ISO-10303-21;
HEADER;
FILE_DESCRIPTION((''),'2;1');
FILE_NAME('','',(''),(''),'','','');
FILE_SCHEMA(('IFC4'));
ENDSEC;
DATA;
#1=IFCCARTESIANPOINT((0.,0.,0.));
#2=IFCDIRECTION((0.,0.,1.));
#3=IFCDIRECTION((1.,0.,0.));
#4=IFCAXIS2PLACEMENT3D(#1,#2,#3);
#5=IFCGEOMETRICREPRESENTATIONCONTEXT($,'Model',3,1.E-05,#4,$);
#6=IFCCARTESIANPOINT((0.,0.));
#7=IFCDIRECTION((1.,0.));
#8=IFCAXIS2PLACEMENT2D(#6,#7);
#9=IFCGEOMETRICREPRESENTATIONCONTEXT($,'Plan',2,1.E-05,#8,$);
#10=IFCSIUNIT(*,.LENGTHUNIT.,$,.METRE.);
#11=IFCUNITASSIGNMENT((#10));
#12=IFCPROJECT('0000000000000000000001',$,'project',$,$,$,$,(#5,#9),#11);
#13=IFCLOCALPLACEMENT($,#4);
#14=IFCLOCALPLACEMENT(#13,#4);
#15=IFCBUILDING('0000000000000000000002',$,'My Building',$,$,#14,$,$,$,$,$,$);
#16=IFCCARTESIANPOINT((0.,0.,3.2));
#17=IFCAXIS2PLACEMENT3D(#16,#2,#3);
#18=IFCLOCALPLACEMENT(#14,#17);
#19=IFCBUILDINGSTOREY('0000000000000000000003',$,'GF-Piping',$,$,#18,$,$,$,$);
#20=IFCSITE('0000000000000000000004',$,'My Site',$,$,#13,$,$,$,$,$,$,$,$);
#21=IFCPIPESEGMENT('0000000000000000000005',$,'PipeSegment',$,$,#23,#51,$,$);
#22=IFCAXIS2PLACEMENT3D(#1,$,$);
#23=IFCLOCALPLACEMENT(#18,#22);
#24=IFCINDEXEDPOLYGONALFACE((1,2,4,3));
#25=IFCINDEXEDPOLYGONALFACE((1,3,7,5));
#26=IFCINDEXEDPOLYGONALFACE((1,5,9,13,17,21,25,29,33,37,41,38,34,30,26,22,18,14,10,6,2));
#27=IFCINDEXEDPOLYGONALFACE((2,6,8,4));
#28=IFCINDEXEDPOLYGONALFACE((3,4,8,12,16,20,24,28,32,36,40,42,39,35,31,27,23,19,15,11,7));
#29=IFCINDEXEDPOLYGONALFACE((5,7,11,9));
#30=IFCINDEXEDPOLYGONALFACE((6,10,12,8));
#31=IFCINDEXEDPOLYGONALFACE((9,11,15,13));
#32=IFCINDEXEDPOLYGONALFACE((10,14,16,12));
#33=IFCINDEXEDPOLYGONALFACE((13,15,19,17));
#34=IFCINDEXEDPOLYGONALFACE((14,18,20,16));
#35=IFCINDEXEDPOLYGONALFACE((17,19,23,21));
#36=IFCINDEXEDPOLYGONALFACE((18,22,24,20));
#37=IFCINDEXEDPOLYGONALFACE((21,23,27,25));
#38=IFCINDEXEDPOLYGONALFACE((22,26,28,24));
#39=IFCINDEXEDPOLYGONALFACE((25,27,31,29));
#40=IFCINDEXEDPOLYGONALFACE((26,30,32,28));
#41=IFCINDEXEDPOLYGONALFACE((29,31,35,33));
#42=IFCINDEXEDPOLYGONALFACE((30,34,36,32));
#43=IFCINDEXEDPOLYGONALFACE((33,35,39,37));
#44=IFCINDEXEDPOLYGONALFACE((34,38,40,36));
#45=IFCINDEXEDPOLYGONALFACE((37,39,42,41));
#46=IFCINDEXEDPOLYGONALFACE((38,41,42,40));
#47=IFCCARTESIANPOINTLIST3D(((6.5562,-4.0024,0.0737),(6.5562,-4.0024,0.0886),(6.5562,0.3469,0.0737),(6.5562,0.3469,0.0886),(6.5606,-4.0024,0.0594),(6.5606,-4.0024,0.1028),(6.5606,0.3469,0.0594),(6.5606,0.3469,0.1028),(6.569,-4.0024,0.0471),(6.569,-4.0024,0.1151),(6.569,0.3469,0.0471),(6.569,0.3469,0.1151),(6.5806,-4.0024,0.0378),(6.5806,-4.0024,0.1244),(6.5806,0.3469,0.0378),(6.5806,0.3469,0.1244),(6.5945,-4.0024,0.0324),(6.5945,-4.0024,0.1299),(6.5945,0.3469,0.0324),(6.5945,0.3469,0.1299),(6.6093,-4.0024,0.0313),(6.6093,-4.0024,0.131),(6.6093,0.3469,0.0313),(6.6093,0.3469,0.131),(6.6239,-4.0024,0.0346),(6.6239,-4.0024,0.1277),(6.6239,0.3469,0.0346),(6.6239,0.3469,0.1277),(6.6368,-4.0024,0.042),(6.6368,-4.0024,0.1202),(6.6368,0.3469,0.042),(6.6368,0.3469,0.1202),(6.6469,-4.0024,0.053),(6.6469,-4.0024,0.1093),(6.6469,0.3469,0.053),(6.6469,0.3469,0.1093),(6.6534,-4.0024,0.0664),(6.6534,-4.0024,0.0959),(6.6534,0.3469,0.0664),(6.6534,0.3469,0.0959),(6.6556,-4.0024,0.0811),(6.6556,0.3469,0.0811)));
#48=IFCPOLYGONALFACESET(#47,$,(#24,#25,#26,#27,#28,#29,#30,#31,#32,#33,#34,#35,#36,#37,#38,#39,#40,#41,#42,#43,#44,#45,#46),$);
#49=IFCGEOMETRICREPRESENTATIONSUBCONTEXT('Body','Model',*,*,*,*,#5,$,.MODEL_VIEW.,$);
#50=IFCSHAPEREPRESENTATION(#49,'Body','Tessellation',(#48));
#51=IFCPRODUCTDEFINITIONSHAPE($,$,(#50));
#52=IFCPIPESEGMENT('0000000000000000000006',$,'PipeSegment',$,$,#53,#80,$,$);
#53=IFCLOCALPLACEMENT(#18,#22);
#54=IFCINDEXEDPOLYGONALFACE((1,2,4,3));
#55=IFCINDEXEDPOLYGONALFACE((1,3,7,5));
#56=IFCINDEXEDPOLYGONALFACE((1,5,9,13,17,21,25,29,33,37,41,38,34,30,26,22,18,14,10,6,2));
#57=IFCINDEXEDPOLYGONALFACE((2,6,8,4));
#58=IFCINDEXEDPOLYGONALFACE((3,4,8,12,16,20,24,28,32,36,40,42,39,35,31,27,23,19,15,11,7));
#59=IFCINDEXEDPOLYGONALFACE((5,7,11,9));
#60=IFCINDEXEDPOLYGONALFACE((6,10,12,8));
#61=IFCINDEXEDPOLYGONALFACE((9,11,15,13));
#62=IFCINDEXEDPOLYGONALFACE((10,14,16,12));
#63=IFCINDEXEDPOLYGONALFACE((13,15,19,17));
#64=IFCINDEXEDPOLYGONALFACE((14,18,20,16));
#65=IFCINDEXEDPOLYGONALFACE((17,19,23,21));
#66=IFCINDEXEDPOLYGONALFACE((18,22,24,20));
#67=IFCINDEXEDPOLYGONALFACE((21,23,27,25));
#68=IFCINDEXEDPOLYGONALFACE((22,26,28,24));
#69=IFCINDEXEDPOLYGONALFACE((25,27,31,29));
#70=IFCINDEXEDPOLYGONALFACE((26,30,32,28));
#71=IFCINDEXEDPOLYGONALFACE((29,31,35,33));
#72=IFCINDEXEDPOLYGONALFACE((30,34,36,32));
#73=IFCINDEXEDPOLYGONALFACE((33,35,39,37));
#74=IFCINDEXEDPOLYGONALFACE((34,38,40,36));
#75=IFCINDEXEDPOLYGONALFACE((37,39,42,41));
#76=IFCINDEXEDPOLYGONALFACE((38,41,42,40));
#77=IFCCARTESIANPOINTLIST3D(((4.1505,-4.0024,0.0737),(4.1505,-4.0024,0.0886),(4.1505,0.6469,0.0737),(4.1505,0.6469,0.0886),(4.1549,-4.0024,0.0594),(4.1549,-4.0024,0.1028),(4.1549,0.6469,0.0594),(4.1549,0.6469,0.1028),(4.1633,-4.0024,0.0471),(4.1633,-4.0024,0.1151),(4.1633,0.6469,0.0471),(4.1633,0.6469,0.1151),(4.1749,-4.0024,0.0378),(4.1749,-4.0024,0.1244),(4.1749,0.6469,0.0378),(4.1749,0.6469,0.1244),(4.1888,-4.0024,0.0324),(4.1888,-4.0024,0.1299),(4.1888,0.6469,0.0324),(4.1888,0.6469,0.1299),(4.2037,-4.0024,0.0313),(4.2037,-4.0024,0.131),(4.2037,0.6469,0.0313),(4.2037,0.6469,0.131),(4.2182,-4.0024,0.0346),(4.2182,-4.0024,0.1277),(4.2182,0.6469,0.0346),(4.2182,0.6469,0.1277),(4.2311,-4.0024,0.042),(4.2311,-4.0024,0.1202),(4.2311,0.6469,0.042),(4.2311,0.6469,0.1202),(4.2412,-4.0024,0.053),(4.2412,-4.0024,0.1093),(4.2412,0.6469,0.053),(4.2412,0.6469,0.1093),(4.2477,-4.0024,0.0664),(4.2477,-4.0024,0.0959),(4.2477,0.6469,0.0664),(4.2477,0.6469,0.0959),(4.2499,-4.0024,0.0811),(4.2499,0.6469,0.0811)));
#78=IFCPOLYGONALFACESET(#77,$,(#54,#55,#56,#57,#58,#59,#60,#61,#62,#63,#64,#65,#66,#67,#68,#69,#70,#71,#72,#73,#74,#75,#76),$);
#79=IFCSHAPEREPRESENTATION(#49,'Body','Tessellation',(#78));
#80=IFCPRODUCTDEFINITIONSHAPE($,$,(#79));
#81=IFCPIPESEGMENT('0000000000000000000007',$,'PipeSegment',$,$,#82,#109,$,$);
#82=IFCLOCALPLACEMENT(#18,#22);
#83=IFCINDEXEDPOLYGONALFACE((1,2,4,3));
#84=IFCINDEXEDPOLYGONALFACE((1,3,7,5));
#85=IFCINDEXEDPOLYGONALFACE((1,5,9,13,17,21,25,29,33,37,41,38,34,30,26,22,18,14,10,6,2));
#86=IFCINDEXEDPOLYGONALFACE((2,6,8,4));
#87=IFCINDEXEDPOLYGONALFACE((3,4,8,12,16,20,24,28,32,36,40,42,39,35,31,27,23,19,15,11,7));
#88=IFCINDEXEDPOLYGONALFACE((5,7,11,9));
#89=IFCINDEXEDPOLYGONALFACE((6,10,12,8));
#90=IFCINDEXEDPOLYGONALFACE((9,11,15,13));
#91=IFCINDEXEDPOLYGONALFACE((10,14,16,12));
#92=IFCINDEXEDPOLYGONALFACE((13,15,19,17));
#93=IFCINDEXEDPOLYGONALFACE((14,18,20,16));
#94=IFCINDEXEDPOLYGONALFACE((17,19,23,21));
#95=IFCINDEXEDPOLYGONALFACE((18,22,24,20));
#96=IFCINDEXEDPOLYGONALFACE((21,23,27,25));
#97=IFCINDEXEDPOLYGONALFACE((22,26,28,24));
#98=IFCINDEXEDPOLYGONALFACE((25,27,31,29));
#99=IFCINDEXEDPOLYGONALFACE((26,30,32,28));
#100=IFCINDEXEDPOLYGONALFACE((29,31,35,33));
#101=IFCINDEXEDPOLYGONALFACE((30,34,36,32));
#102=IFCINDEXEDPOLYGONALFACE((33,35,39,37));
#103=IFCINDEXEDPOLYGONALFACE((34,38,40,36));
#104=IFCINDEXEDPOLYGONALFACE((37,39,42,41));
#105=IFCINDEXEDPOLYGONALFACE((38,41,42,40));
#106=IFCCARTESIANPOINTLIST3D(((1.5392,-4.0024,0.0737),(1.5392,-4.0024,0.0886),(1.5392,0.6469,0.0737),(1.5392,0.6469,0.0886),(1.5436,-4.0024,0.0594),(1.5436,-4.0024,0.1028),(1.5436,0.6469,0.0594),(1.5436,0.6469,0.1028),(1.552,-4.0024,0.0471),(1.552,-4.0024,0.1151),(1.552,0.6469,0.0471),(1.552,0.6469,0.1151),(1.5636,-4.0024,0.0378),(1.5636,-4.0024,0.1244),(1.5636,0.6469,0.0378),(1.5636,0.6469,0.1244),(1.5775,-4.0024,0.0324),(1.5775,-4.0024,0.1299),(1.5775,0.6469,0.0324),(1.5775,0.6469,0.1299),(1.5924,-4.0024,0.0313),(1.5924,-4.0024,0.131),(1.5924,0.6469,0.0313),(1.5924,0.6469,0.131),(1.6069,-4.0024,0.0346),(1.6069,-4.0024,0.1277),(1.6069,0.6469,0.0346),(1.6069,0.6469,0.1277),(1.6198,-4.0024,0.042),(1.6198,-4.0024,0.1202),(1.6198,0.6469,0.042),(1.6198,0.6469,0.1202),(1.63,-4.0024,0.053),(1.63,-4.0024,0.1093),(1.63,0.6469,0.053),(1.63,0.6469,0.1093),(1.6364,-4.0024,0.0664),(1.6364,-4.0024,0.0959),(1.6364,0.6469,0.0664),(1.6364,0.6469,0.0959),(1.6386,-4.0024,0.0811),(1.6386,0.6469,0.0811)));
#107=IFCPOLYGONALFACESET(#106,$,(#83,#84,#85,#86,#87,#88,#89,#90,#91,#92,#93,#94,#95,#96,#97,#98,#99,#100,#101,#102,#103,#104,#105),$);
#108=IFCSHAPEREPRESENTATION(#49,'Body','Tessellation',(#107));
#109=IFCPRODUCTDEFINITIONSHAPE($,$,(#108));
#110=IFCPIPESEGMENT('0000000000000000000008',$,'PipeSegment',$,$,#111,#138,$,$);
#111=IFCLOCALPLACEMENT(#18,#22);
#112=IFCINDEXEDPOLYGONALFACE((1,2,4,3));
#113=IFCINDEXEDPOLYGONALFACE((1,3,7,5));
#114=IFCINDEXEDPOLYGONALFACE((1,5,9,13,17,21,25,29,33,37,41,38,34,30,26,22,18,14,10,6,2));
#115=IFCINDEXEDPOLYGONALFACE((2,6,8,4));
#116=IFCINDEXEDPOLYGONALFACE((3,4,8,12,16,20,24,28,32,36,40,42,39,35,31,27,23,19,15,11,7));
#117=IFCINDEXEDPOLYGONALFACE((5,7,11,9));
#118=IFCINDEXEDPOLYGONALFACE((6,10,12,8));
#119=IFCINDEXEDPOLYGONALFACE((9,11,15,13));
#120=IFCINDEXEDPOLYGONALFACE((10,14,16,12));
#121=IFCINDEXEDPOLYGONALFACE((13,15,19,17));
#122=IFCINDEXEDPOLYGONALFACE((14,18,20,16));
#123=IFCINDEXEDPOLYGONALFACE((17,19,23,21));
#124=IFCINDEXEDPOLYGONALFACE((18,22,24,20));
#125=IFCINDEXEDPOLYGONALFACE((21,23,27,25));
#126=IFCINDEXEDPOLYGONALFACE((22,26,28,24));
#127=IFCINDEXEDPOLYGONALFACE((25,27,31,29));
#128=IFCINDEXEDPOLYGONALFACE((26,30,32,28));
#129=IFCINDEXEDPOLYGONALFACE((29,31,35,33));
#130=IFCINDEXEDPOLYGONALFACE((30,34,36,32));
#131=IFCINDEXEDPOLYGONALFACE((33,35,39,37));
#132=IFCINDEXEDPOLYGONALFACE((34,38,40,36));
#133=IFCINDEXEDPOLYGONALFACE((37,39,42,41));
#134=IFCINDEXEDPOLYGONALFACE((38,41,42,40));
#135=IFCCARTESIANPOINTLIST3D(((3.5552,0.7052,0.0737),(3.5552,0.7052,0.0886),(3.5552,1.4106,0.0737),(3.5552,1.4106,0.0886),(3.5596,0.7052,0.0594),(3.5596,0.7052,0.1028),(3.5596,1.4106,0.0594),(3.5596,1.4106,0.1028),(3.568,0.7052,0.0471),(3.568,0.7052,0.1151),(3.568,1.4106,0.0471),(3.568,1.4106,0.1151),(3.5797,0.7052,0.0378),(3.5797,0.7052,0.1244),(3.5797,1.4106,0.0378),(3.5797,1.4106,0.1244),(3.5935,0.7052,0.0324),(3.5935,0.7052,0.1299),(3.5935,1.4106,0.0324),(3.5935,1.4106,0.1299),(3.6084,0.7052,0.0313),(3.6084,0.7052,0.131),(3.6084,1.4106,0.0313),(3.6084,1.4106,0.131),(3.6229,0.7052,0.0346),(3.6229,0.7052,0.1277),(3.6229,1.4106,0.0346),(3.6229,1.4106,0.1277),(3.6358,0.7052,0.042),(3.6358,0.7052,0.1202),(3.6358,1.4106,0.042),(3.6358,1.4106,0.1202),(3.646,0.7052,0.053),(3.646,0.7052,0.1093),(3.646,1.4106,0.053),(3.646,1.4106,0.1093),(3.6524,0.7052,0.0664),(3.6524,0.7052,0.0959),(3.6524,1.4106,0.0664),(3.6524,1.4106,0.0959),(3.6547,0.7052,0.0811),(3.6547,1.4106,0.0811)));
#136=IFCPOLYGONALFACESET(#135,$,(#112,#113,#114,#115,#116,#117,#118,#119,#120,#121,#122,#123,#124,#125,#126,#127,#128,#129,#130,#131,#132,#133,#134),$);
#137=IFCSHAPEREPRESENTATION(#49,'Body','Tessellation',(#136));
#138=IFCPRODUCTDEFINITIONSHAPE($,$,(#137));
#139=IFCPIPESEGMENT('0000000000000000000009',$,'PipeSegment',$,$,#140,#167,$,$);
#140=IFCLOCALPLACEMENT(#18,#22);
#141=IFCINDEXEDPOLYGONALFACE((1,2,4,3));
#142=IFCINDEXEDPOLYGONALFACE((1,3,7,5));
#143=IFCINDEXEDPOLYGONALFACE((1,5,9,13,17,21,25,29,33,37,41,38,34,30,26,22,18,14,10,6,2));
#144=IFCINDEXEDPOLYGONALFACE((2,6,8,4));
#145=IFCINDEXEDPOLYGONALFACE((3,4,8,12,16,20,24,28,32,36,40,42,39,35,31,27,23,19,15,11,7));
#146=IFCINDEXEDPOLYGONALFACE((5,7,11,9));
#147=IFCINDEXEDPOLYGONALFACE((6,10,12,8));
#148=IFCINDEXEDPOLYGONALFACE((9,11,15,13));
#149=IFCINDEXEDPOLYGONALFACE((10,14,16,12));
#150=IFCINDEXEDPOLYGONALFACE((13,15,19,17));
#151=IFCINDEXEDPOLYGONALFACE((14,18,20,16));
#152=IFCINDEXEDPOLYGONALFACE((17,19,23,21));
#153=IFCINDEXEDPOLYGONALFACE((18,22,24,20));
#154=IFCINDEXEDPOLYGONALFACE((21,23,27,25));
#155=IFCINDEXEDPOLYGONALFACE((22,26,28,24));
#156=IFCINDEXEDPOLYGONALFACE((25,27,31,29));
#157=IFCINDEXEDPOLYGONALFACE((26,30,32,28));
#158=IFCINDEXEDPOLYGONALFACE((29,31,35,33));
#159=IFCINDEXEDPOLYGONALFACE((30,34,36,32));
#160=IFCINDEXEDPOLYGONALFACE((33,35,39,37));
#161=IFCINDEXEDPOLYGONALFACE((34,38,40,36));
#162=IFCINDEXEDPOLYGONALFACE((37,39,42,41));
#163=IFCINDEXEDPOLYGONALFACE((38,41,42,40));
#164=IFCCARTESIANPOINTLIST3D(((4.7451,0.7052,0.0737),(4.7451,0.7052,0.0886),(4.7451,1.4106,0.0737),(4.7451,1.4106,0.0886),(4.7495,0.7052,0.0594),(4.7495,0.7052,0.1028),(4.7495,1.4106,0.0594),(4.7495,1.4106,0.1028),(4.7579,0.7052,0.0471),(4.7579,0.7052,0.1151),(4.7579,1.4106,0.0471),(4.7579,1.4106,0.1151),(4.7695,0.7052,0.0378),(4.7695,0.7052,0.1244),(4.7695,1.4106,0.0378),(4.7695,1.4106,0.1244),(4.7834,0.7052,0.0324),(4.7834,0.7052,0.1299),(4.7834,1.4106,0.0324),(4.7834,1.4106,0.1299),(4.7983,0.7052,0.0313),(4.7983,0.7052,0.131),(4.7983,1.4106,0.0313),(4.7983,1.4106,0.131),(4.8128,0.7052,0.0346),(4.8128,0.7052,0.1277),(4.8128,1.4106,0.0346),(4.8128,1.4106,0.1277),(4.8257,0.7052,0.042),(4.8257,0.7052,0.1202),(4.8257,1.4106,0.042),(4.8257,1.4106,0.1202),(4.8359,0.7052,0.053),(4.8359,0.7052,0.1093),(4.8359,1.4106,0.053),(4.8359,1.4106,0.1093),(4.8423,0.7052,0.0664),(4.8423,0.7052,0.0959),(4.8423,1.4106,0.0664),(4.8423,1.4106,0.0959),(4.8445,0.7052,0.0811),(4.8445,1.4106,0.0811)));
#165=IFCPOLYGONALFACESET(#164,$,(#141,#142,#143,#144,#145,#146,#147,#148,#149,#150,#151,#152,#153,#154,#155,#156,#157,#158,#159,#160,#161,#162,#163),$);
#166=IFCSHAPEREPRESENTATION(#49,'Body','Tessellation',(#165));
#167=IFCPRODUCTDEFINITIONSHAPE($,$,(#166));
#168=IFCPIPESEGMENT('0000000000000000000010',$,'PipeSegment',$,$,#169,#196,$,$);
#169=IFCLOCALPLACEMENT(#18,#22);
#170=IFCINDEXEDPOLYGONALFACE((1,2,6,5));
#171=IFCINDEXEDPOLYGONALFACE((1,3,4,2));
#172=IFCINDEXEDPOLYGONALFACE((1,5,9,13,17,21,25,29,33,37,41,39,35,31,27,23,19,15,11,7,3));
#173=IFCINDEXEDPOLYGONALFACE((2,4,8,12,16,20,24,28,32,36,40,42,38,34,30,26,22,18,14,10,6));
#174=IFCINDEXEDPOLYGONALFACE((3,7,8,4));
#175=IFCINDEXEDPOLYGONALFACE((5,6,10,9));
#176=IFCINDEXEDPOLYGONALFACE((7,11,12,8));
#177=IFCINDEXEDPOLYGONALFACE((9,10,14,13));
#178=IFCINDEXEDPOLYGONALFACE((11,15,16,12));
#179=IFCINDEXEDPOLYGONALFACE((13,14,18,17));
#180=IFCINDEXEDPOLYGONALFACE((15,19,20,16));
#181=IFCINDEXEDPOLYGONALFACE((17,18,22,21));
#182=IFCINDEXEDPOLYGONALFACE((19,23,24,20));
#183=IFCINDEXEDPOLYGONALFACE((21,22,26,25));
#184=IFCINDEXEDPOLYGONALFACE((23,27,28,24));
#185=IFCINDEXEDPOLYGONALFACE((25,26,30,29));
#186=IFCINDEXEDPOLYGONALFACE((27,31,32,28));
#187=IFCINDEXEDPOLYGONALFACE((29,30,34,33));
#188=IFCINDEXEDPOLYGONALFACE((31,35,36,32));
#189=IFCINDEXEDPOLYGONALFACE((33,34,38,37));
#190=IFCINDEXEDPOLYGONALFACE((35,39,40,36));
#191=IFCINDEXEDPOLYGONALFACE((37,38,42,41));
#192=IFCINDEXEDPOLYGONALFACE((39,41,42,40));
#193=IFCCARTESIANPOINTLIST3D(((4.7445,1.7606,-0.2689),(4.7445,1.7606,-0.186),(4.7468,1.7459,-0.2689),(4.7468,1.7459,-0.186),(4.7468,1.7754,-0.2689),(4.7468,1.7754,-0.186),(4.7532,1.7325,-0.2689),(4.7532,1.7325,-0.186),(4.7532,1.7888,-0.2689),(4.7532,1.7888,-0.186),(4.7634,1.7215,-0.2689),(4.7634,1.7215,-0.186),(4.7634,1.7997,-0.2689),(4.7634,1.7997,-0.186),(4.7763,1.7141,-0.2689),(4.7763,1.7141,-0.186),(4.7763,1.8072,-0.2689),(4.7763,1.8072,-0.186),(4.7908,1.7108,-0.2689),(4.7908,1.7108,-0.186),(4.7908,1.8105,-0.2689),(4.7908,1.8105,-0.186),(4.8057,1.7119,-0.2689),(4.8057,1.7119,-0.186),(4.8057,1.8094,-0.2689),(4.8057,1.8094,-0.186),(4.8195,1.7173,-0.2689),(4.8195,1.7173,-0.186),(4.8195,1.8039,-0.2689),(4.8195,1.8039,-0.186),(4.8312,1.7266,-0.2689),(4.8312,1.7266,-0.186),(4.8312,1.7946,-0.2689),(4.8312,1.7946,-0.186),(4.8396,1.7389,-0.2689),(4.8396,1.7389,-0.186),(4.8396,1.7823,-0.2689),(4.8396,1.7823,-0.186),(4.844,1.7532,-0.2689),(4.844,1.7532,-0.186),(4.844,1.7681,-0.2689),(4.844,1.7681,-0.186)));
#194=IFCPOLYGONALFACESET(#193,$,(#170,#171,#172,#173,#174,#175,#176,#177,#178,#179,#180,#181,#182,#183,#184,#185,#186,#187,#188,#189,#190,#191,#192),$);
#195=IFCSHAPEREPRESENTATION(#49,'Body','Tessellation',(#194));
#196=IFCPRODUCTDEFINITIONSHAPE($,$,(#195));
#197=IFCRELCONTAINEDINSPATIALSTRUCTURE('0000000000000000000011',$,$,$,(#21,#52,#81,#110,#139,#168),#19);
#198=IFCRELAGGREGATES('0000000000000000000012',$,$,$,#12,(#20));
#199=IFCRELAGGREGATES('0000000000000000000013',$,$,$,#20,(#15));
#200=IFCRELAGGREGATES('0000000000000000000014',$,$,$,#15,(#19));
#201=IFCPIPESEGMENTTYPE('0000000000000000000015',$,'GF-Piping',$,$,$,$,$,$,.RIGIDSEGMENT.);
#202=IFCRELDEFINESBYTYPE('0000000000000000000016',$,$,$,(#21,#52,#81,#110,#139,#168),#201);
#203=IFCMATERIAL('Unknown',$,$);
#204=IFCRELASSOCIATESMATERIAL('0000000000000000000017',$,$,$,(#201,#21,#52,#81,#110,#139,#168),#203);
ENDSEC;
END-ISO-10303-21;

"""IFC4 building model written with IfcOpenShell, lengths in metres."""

from ifc_helpers import new_model, si_unit, frame, origin_with_axes, origin_2d_with_axis, place, context, subcontext, project, spatial, circle, extrude, material, material_profile, profile_set, profile_usage, type_object, element, save


model = new_model("IFC4")

# Units and contexts
model_context = context("Model", 3, precision=1e-05, world=origin_with_axes())
plan_context = context("Plan", 2, precision=1e-05, world=origin_2d_with_axis())
body_context = subcontext(model_context, "Body", "Model", "MODEL_VIEW")
ifc_project = project(units=[si_unit("LENGTHUNIT", "METRE")], contexts=[model_context, plan_context])

# Site, building, storey
site_placement = place(None, origin_with_axes())
site = spatial("IfcSite", under=ifc_project, at=site_placement, Name="My Site")
building_placement = place(site_placement, origin_with_axes())
building = spatial("IfcBuilding", under=site, at=building_placement, Name="My Building")
storey_placement = place(building_placement, frame((0.0, 0.0, 3.2), z_axis=(0.0, 0.0, 1.0), x_axis=(1.0, 0.0, 0.0)))
storey = spatial("IfcBuildingStorey", under=building, at=storey_placement, Name="GF-Piping")

# Pipe segments
ifc_material = material(Name="Unknown")
ifc_material_profile = material_profile(ifc_material, circle(Radius=0.05))
ifc_profile_set = profile_set([ifc_material_profile])
ifc_profile_usage_1 = profile_usage(ifc_profile_set, cardinal=5)
pipe_segment_type = type_object("IfcPipeSegmentType", Name="GF-Piping", PredefinedType="RIGIDSEGMENT", material=ifc_profile_set)
pipe_segment_1_placement = place(storey_placement, frame((6.6056, 0.3469, 0.0811), z_axis=(0.0, -1.0, 0.0), x_axis=(1.0, 0.0, 0.0)))
element("IfcPipeSegment", 1, at=pipe_segment_1_placement, inside=storey, type_object=pipe_segment_type, material=ifc_profile_usage_1, Name="PipeSegment", context=body_context, shape_type="SweptSolid", body=[
    extrude(circle(Radius=0.05), origin_with_axes(), (0.0, 0.0, 1.0), 4.3492),
])
ifc_profile_usage_2 = profile_usage(ifc_profile_set, cardinal=5)
pipe_segment_2_placement = place(storey_placement, frame((4.1999, 0.6469, 0.0811), z_axis=(0.0, -1.0, 0.0), x_axis=(1.0, 0.0, 0.0)))
element("IfcPipeSegment", 2, at=pipe_segment_2_placement, inside=storey, type_object=pipe_segment_type, material=ifc_profile_usage_2, Name="PipeSegment", context=body_context, shape_type="SweptSolid", body=[
    extrude(circle(Radius=0.05), origin_with_axes(), (0.0, 0.0, 1.0), 4.6492),
])
ifc_profile_usage_3 = profile_usage(ifc_profile_set, cardinal=5)
pipe_segment_3_placement = place(storey_placement, frame((1.5886, 0.6469, 0.0811), z_axis=(0.0, -1.0, 0.0), x_axis=(1.0, 0.0, 0.0)))
element("IfcPipeSegment", 3, at=pipe_segment_3_placement, inside=storey, type_object=pipe_segment_type, material=ifc_profile_usage_3, Name="PipeSegment", context=body_context, shape_type="SweptSolid", body=[
    extrude(circle(Radius=0.05), origin_with_axes(), (0.0, 0.0, 1.0), 4.6492),
])
ifc_profile_usage_4 = profile_usage(ifc_profile_set, cardinal=5)
pipe_segment_4_placement = place(storey_placement, frame((3.6047, 1.4106, 0.0811), z_axis=(0.0, -1.0, 0.0), x_axis=(1.0, 0.0, 0.0)))
element("IfcPipeSegment", 4, at=pipe_segment_4_placement, inside=storey, type_object=pipe_segment_type, material=ifc_profile_usage_4, Name="PipeSegment", context=body_context, shape_type="SweptSolid", body=[
    extrude(circle(Radius=0.05), origin_with_axes(), (0.0, 0.0, 1.0), 0.7054),
])
ifc_profile_usage_5 = profile_usage(ifc_profile_set, cardinal=5)
pipe_segment_5_placement = place(storey_placement, frame((4.7945, 1.4106, 0.0811), z_axis=(0.0, -1.0, 0.0), x_axis=(1.0, 0.0, 0.0)))
element("IfcPipeSegment", 5, at=pipe_segment_5_placement, inside=storey, type_object=pipe_segment_type, material=ifc_profile_usage_5, Name="PipeSegment", context=body_context, shape_type="SweptSolid", body=[
    extrude(circle(Radius=0.05), origin_with_axes(), (0.0, 0.0, 1.0), 0.7054),
])
ifc_profile_usage_6 = profile_usage(ifc_profile_set, cardinal=5)
pipe_segment_6_placement = place(storey_placement, frame((4.7945, 1.7606, -0.186), z_axis=(0.0, 0.0, -1.0), x_axis=(-1.0, 0.0, 0.0)))
element("IfcPipeSegment", 6, at=pipe_segment_6_placement, inside=storey, type_object=pipe_segment_type, material=ifc_profile_usage_6, Name="PipeSegment", context=body_context, shape_type="SweptSolid", body=[
    extrude(circle(Radius=0.05), origin_with_axes(), (0.0, 0.0, 1.0), 0.0828),
])

save(model, "model.ifc")
